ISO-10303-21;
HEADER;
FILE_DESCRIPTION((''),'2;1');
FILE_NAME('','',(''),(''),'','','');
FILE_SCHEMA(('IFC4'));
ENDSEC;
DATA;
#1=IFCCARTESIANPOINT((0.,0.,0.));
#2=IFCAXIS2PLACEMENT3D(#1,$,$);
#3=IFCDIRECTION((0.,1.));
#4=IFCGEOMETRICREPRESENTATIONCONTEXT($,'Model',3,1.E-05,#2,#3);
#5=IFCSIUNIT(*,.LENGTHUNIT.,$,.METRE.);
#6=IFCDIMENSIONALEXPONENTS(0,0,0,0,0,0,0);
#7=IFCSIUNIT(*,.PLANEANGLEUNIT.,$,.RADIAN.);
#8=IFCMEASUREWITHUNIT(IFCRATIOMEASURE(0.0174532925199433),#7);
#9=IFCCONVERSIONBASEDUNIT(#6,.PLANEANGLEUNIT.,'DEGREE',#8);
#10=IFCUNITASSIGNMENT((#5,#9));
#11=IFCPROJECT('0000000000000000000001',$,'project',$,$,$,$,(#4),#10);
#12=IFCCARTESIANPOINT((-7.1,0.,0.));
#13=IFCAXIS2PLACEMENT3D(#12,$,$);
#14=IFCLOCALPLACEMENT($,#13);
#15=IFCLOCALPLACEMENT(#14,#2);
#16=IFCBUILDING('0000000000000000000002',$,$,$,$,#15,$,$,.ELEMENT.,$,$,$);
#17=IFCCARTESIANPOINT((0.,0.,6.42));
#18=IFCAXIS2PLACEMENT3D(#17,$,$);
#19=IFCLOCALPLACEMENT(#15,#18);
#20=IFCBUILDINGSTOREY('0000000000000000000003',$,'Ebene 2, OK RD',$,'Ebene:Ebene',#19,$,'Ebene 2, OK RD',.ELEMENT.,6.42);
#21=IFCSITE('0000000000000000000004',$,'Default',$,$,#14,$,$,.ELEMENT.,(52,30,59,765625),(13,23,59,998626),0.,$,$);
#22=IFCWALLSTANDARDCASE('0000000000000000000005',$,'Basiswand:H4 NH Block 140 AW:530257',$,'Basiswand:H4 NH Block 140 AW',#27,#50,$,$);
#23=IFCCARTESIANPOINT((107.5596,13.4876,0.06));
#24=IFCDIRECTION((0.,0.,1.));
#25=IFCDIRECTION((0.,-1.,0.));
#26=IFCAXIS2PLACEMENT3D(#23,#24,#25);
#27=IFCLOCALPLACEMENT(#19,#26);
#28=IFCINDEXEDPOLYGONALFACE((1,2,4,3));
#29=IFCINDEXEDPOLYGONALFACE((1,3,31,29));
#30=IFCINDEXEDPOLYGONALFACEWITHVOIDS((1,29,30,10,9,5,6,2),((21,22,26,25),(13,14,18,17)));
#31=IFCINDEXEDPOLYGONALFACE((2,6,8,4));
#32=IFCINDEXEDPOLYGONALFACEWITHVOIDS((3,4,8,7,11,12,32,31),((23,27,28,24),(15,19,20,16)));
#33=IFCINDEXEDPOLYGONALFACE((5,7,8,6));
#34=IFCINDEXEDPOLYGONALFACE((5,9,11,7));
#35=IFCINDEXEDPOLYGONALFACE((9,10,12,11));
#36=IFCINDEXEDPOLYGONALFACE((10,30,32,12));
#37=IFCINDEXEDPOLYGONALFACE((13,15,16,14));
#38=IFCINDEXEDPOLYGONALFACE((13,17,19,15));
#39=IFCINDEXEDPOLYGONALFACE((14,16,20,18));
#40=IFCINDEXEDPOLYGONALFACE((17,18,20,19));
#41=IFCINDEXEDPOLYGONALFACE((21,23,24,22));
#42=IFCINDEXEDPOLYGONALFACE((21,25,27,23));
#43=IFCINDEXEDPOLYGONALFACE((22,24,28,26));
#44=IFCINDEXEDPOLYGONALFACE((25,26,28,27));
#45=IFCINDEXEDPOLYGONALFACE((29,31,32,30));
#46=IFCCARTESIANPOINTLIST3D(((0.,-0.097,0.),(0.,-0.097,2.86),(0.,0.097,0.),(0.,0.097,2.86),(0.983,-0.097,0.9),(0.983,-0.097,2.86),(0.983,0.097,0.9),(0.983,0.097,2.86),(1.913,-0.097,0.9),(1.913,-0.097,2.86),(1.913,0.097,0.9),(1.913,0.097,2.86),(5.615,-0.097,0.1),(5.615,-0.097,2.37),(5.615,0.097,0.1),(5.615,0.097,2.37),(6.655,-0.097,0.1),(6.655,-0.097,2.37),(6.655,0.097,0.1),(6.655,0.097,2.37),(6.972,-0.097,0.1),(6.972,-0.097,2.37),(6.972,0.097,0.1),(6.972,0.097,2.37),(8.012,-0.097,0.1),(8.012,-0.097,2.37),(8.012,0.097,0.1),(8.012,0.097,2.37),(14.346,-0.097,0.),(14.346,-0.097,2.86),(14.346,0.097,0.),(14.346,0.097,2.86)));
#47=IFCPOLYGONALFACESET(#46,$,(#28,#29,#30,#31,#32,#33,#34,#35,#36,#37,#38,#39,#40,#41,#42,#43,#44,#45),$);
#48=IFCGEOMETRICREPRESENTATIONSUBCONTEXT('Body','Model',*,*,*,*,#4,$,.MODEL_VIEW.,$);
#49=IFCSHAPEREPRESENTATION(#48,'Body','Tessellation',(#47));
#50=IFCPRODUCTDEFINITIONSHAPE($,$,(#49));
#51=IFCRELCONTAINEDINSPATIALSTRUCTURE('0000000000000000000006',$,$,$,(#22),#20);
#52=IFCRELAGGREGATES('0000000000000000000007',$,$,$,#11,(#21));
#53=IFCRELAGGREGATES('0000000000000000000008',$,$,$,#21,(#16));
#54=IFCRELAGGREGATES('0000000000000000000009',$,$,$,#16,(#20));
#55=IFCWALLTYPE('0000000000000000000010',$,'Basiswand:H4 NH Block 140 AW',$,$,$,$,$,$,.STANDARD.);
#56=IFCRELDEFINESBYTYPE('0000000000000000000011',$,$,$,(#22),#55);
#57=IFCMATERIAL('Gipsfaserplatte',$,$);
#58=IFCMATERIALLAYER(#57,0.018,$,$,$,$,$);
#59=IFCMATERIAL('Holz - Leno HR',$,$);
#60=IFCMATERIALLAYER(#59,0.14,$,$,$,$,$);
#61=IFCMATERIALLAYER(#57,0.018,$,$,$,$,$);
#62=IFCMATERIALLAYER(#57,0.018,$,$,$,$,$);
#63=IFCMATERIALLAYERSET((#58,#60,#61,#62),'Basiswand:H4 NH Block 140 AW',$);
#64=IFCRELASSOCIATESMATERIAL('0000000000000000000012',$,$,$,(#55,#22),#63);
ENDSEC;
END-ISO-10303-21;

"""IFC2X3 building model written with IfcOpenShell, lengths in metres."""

from ifc_helpers import new_model, entity, si_unit, converted_unit, direction, frame, frame_2d, origin, place, context, subcontext, project, spatial, rectangle, extrude, material, layer, layer_set, layer_usage, type_object, element, save


model = new_model("IFC2X3")

# Units and contexts
model_context = context("Model", 3, precision=1e-05, world=origin(), true_north=direction((0.0, 1.0)))
body_context = subcontext(model_context, "Body", "Model", "MODEL_VIEW")
ifc_project = project(units=[si_unit("LENGTHUNIT", "METRE"), converted_unit("PLANEANGLEUNIT", "DEGREE", entity("IfcRatioMeasure", 0.0174532925199433), si_unit("PLANEANGLEUNIT", "RADIAN"), dimensions=[0, 0, 0, 0, 0, 0, 0])], contexts=[model_context])

# Site, building, storey
site_placement = place(None, frame((-7.1, 0.0, 0.0)))
site = spatial("IfcSite", under=ifc_project, at=site_placement, Name="Default", CompositionType="ELEMENT", RefLatitude=(52, 30, 59, 765625), RefLongitude=(13, 23, 59, 998626), RefElevation=0.0)
building_placement = place(site_placement, origin())
building = spatial("IfcBuilding", under=site, at=building_placement, CompositionType="ELEMENT")
storey_placement = place(building_placement, frame((0.0, 0.0, 6.42)))
storey = spatial("IfcBuildingStorey", under=building, at=storey_placement, Name="Ebene 2, OK RD", ObjectType="Ebene:Ebene", LongName="Ebene 2, OK RD", CompositionType="ELEMENT", Elevation=6.42)

# Shared definitions
ifc_material_1 = material(Name="Gipsfaserplatte")

# Shared definitions
ifc_layer_1 = layer(ifc_material_1, 0.018)
ifc_material_2 = material(Name="Holz - Leno HR")
ifc_layer_2 = layer(ifc_material_2, 0.14)
ifc_layer_3 = layer(ifc_material_1, 0.018)
ifc_layer_4 = layer(ifc_material_1, 0.018)
ifc_layer_set_1 = layer_set([ifc_layer_1, ifc_layer_2, ifc_layer_3, ifc_layer_4], Name="Basiswand:H4 NH Block 140 AW")
wall_type_1 = type_object("IfcWallType", Name="Basiswand:H4 NH Block 140 AW", PredefinedType="STANDARD", material=ifc_layer_set_1)

# Wall, openings
ifc_layer_usage_1 = layer_usage(ifc_layer_set_1, "AXIS2", "NEGATIVE", 0.097)
wall_1_placement = place(storey_placement, frame((107.5596, 13.4876, 0.06), z_axis=(0.0, 0.0, 1.0), x_axis=(0.0, -1.0, 0.0)))
wall_1 = element("IfcWallStandardCase", 1, at=wall_1_placement, inside=storey, type_object=wall_type_1, material=ifc_layer_usage_1, Name="Basiswand:H4 NH Block 140 AW:530257", ObjectType="Basiswand:H4 NH Block 140 AW", context=body_context, shape_type="SweptSolid", body=[
    extrude(rectangle(XDim=14.346, YDim=0.194, at=frame_2d((7.173, 0.0), x_axis=(-1.0, 0.0))), origin(), (0.0, 0.0, 1.0), 2.86),
])
opening_1_placement = place(wall_1_placement, origin())
element("IfcOpeningElement", 2, at=opening_1_placement, cuts=wall_1, ObjectType="Opening", context=body_context, shape_type="SweptSolid", body=[
    extrude(rectangle(XDim=2.0, YDim=0.93, at=frame_2d((0.0, 0.0), x_axis=(1.0, 0.0))), frame((1.448, -0.097, 1.9), z_axis=(0.0, 1.0, 0.0), x_axis=(0.0, 0.0, -1.0)), (0.0, 0.0, 1.0), 0.194),
])
opening_2_placement = place(wall_1_placement, origin())
element("IfcOpeningElement", 3, at=opening_2_placement, cuts=wall_1, ObjectType="Opening", context=body_context, shape_type="SweptSolid", body=[
    extrude(rectangle(XDim=2.27, YDim=1.04, at=frame_2d((0.0, 0.0), x_axis=(1.0, 0.0))), frame((6.135, -0.097, 1.235), z_axis=(0.0, 1.0, 0.0), x_axis=(0.0, 0.0, -1.0)), (0.0, 0.0, 1.0), 0.194),
])
opening_3_placement = place(wall_1_placement, origin())
element("IfcOpeningElement", 4, at=opening_3_placement, cuts=wall_1, ObjectType="Opening", context=body_context, shape_type="SweptSolid", body=[
    extrude(rectangle(XDim=2.27, YDim=1.04, at=frame_2d((0.0, 0.0), x_axis=(1.0, 0.0))), frame((7.492, -0.097, 1.235), z_axis=(0.0, 1.0, 0.0), x_axis=(0.0, 0.0, -1.0)), (0.0, 0.0, 1.0), 0.194),
])

save(model, "model.ifc")
